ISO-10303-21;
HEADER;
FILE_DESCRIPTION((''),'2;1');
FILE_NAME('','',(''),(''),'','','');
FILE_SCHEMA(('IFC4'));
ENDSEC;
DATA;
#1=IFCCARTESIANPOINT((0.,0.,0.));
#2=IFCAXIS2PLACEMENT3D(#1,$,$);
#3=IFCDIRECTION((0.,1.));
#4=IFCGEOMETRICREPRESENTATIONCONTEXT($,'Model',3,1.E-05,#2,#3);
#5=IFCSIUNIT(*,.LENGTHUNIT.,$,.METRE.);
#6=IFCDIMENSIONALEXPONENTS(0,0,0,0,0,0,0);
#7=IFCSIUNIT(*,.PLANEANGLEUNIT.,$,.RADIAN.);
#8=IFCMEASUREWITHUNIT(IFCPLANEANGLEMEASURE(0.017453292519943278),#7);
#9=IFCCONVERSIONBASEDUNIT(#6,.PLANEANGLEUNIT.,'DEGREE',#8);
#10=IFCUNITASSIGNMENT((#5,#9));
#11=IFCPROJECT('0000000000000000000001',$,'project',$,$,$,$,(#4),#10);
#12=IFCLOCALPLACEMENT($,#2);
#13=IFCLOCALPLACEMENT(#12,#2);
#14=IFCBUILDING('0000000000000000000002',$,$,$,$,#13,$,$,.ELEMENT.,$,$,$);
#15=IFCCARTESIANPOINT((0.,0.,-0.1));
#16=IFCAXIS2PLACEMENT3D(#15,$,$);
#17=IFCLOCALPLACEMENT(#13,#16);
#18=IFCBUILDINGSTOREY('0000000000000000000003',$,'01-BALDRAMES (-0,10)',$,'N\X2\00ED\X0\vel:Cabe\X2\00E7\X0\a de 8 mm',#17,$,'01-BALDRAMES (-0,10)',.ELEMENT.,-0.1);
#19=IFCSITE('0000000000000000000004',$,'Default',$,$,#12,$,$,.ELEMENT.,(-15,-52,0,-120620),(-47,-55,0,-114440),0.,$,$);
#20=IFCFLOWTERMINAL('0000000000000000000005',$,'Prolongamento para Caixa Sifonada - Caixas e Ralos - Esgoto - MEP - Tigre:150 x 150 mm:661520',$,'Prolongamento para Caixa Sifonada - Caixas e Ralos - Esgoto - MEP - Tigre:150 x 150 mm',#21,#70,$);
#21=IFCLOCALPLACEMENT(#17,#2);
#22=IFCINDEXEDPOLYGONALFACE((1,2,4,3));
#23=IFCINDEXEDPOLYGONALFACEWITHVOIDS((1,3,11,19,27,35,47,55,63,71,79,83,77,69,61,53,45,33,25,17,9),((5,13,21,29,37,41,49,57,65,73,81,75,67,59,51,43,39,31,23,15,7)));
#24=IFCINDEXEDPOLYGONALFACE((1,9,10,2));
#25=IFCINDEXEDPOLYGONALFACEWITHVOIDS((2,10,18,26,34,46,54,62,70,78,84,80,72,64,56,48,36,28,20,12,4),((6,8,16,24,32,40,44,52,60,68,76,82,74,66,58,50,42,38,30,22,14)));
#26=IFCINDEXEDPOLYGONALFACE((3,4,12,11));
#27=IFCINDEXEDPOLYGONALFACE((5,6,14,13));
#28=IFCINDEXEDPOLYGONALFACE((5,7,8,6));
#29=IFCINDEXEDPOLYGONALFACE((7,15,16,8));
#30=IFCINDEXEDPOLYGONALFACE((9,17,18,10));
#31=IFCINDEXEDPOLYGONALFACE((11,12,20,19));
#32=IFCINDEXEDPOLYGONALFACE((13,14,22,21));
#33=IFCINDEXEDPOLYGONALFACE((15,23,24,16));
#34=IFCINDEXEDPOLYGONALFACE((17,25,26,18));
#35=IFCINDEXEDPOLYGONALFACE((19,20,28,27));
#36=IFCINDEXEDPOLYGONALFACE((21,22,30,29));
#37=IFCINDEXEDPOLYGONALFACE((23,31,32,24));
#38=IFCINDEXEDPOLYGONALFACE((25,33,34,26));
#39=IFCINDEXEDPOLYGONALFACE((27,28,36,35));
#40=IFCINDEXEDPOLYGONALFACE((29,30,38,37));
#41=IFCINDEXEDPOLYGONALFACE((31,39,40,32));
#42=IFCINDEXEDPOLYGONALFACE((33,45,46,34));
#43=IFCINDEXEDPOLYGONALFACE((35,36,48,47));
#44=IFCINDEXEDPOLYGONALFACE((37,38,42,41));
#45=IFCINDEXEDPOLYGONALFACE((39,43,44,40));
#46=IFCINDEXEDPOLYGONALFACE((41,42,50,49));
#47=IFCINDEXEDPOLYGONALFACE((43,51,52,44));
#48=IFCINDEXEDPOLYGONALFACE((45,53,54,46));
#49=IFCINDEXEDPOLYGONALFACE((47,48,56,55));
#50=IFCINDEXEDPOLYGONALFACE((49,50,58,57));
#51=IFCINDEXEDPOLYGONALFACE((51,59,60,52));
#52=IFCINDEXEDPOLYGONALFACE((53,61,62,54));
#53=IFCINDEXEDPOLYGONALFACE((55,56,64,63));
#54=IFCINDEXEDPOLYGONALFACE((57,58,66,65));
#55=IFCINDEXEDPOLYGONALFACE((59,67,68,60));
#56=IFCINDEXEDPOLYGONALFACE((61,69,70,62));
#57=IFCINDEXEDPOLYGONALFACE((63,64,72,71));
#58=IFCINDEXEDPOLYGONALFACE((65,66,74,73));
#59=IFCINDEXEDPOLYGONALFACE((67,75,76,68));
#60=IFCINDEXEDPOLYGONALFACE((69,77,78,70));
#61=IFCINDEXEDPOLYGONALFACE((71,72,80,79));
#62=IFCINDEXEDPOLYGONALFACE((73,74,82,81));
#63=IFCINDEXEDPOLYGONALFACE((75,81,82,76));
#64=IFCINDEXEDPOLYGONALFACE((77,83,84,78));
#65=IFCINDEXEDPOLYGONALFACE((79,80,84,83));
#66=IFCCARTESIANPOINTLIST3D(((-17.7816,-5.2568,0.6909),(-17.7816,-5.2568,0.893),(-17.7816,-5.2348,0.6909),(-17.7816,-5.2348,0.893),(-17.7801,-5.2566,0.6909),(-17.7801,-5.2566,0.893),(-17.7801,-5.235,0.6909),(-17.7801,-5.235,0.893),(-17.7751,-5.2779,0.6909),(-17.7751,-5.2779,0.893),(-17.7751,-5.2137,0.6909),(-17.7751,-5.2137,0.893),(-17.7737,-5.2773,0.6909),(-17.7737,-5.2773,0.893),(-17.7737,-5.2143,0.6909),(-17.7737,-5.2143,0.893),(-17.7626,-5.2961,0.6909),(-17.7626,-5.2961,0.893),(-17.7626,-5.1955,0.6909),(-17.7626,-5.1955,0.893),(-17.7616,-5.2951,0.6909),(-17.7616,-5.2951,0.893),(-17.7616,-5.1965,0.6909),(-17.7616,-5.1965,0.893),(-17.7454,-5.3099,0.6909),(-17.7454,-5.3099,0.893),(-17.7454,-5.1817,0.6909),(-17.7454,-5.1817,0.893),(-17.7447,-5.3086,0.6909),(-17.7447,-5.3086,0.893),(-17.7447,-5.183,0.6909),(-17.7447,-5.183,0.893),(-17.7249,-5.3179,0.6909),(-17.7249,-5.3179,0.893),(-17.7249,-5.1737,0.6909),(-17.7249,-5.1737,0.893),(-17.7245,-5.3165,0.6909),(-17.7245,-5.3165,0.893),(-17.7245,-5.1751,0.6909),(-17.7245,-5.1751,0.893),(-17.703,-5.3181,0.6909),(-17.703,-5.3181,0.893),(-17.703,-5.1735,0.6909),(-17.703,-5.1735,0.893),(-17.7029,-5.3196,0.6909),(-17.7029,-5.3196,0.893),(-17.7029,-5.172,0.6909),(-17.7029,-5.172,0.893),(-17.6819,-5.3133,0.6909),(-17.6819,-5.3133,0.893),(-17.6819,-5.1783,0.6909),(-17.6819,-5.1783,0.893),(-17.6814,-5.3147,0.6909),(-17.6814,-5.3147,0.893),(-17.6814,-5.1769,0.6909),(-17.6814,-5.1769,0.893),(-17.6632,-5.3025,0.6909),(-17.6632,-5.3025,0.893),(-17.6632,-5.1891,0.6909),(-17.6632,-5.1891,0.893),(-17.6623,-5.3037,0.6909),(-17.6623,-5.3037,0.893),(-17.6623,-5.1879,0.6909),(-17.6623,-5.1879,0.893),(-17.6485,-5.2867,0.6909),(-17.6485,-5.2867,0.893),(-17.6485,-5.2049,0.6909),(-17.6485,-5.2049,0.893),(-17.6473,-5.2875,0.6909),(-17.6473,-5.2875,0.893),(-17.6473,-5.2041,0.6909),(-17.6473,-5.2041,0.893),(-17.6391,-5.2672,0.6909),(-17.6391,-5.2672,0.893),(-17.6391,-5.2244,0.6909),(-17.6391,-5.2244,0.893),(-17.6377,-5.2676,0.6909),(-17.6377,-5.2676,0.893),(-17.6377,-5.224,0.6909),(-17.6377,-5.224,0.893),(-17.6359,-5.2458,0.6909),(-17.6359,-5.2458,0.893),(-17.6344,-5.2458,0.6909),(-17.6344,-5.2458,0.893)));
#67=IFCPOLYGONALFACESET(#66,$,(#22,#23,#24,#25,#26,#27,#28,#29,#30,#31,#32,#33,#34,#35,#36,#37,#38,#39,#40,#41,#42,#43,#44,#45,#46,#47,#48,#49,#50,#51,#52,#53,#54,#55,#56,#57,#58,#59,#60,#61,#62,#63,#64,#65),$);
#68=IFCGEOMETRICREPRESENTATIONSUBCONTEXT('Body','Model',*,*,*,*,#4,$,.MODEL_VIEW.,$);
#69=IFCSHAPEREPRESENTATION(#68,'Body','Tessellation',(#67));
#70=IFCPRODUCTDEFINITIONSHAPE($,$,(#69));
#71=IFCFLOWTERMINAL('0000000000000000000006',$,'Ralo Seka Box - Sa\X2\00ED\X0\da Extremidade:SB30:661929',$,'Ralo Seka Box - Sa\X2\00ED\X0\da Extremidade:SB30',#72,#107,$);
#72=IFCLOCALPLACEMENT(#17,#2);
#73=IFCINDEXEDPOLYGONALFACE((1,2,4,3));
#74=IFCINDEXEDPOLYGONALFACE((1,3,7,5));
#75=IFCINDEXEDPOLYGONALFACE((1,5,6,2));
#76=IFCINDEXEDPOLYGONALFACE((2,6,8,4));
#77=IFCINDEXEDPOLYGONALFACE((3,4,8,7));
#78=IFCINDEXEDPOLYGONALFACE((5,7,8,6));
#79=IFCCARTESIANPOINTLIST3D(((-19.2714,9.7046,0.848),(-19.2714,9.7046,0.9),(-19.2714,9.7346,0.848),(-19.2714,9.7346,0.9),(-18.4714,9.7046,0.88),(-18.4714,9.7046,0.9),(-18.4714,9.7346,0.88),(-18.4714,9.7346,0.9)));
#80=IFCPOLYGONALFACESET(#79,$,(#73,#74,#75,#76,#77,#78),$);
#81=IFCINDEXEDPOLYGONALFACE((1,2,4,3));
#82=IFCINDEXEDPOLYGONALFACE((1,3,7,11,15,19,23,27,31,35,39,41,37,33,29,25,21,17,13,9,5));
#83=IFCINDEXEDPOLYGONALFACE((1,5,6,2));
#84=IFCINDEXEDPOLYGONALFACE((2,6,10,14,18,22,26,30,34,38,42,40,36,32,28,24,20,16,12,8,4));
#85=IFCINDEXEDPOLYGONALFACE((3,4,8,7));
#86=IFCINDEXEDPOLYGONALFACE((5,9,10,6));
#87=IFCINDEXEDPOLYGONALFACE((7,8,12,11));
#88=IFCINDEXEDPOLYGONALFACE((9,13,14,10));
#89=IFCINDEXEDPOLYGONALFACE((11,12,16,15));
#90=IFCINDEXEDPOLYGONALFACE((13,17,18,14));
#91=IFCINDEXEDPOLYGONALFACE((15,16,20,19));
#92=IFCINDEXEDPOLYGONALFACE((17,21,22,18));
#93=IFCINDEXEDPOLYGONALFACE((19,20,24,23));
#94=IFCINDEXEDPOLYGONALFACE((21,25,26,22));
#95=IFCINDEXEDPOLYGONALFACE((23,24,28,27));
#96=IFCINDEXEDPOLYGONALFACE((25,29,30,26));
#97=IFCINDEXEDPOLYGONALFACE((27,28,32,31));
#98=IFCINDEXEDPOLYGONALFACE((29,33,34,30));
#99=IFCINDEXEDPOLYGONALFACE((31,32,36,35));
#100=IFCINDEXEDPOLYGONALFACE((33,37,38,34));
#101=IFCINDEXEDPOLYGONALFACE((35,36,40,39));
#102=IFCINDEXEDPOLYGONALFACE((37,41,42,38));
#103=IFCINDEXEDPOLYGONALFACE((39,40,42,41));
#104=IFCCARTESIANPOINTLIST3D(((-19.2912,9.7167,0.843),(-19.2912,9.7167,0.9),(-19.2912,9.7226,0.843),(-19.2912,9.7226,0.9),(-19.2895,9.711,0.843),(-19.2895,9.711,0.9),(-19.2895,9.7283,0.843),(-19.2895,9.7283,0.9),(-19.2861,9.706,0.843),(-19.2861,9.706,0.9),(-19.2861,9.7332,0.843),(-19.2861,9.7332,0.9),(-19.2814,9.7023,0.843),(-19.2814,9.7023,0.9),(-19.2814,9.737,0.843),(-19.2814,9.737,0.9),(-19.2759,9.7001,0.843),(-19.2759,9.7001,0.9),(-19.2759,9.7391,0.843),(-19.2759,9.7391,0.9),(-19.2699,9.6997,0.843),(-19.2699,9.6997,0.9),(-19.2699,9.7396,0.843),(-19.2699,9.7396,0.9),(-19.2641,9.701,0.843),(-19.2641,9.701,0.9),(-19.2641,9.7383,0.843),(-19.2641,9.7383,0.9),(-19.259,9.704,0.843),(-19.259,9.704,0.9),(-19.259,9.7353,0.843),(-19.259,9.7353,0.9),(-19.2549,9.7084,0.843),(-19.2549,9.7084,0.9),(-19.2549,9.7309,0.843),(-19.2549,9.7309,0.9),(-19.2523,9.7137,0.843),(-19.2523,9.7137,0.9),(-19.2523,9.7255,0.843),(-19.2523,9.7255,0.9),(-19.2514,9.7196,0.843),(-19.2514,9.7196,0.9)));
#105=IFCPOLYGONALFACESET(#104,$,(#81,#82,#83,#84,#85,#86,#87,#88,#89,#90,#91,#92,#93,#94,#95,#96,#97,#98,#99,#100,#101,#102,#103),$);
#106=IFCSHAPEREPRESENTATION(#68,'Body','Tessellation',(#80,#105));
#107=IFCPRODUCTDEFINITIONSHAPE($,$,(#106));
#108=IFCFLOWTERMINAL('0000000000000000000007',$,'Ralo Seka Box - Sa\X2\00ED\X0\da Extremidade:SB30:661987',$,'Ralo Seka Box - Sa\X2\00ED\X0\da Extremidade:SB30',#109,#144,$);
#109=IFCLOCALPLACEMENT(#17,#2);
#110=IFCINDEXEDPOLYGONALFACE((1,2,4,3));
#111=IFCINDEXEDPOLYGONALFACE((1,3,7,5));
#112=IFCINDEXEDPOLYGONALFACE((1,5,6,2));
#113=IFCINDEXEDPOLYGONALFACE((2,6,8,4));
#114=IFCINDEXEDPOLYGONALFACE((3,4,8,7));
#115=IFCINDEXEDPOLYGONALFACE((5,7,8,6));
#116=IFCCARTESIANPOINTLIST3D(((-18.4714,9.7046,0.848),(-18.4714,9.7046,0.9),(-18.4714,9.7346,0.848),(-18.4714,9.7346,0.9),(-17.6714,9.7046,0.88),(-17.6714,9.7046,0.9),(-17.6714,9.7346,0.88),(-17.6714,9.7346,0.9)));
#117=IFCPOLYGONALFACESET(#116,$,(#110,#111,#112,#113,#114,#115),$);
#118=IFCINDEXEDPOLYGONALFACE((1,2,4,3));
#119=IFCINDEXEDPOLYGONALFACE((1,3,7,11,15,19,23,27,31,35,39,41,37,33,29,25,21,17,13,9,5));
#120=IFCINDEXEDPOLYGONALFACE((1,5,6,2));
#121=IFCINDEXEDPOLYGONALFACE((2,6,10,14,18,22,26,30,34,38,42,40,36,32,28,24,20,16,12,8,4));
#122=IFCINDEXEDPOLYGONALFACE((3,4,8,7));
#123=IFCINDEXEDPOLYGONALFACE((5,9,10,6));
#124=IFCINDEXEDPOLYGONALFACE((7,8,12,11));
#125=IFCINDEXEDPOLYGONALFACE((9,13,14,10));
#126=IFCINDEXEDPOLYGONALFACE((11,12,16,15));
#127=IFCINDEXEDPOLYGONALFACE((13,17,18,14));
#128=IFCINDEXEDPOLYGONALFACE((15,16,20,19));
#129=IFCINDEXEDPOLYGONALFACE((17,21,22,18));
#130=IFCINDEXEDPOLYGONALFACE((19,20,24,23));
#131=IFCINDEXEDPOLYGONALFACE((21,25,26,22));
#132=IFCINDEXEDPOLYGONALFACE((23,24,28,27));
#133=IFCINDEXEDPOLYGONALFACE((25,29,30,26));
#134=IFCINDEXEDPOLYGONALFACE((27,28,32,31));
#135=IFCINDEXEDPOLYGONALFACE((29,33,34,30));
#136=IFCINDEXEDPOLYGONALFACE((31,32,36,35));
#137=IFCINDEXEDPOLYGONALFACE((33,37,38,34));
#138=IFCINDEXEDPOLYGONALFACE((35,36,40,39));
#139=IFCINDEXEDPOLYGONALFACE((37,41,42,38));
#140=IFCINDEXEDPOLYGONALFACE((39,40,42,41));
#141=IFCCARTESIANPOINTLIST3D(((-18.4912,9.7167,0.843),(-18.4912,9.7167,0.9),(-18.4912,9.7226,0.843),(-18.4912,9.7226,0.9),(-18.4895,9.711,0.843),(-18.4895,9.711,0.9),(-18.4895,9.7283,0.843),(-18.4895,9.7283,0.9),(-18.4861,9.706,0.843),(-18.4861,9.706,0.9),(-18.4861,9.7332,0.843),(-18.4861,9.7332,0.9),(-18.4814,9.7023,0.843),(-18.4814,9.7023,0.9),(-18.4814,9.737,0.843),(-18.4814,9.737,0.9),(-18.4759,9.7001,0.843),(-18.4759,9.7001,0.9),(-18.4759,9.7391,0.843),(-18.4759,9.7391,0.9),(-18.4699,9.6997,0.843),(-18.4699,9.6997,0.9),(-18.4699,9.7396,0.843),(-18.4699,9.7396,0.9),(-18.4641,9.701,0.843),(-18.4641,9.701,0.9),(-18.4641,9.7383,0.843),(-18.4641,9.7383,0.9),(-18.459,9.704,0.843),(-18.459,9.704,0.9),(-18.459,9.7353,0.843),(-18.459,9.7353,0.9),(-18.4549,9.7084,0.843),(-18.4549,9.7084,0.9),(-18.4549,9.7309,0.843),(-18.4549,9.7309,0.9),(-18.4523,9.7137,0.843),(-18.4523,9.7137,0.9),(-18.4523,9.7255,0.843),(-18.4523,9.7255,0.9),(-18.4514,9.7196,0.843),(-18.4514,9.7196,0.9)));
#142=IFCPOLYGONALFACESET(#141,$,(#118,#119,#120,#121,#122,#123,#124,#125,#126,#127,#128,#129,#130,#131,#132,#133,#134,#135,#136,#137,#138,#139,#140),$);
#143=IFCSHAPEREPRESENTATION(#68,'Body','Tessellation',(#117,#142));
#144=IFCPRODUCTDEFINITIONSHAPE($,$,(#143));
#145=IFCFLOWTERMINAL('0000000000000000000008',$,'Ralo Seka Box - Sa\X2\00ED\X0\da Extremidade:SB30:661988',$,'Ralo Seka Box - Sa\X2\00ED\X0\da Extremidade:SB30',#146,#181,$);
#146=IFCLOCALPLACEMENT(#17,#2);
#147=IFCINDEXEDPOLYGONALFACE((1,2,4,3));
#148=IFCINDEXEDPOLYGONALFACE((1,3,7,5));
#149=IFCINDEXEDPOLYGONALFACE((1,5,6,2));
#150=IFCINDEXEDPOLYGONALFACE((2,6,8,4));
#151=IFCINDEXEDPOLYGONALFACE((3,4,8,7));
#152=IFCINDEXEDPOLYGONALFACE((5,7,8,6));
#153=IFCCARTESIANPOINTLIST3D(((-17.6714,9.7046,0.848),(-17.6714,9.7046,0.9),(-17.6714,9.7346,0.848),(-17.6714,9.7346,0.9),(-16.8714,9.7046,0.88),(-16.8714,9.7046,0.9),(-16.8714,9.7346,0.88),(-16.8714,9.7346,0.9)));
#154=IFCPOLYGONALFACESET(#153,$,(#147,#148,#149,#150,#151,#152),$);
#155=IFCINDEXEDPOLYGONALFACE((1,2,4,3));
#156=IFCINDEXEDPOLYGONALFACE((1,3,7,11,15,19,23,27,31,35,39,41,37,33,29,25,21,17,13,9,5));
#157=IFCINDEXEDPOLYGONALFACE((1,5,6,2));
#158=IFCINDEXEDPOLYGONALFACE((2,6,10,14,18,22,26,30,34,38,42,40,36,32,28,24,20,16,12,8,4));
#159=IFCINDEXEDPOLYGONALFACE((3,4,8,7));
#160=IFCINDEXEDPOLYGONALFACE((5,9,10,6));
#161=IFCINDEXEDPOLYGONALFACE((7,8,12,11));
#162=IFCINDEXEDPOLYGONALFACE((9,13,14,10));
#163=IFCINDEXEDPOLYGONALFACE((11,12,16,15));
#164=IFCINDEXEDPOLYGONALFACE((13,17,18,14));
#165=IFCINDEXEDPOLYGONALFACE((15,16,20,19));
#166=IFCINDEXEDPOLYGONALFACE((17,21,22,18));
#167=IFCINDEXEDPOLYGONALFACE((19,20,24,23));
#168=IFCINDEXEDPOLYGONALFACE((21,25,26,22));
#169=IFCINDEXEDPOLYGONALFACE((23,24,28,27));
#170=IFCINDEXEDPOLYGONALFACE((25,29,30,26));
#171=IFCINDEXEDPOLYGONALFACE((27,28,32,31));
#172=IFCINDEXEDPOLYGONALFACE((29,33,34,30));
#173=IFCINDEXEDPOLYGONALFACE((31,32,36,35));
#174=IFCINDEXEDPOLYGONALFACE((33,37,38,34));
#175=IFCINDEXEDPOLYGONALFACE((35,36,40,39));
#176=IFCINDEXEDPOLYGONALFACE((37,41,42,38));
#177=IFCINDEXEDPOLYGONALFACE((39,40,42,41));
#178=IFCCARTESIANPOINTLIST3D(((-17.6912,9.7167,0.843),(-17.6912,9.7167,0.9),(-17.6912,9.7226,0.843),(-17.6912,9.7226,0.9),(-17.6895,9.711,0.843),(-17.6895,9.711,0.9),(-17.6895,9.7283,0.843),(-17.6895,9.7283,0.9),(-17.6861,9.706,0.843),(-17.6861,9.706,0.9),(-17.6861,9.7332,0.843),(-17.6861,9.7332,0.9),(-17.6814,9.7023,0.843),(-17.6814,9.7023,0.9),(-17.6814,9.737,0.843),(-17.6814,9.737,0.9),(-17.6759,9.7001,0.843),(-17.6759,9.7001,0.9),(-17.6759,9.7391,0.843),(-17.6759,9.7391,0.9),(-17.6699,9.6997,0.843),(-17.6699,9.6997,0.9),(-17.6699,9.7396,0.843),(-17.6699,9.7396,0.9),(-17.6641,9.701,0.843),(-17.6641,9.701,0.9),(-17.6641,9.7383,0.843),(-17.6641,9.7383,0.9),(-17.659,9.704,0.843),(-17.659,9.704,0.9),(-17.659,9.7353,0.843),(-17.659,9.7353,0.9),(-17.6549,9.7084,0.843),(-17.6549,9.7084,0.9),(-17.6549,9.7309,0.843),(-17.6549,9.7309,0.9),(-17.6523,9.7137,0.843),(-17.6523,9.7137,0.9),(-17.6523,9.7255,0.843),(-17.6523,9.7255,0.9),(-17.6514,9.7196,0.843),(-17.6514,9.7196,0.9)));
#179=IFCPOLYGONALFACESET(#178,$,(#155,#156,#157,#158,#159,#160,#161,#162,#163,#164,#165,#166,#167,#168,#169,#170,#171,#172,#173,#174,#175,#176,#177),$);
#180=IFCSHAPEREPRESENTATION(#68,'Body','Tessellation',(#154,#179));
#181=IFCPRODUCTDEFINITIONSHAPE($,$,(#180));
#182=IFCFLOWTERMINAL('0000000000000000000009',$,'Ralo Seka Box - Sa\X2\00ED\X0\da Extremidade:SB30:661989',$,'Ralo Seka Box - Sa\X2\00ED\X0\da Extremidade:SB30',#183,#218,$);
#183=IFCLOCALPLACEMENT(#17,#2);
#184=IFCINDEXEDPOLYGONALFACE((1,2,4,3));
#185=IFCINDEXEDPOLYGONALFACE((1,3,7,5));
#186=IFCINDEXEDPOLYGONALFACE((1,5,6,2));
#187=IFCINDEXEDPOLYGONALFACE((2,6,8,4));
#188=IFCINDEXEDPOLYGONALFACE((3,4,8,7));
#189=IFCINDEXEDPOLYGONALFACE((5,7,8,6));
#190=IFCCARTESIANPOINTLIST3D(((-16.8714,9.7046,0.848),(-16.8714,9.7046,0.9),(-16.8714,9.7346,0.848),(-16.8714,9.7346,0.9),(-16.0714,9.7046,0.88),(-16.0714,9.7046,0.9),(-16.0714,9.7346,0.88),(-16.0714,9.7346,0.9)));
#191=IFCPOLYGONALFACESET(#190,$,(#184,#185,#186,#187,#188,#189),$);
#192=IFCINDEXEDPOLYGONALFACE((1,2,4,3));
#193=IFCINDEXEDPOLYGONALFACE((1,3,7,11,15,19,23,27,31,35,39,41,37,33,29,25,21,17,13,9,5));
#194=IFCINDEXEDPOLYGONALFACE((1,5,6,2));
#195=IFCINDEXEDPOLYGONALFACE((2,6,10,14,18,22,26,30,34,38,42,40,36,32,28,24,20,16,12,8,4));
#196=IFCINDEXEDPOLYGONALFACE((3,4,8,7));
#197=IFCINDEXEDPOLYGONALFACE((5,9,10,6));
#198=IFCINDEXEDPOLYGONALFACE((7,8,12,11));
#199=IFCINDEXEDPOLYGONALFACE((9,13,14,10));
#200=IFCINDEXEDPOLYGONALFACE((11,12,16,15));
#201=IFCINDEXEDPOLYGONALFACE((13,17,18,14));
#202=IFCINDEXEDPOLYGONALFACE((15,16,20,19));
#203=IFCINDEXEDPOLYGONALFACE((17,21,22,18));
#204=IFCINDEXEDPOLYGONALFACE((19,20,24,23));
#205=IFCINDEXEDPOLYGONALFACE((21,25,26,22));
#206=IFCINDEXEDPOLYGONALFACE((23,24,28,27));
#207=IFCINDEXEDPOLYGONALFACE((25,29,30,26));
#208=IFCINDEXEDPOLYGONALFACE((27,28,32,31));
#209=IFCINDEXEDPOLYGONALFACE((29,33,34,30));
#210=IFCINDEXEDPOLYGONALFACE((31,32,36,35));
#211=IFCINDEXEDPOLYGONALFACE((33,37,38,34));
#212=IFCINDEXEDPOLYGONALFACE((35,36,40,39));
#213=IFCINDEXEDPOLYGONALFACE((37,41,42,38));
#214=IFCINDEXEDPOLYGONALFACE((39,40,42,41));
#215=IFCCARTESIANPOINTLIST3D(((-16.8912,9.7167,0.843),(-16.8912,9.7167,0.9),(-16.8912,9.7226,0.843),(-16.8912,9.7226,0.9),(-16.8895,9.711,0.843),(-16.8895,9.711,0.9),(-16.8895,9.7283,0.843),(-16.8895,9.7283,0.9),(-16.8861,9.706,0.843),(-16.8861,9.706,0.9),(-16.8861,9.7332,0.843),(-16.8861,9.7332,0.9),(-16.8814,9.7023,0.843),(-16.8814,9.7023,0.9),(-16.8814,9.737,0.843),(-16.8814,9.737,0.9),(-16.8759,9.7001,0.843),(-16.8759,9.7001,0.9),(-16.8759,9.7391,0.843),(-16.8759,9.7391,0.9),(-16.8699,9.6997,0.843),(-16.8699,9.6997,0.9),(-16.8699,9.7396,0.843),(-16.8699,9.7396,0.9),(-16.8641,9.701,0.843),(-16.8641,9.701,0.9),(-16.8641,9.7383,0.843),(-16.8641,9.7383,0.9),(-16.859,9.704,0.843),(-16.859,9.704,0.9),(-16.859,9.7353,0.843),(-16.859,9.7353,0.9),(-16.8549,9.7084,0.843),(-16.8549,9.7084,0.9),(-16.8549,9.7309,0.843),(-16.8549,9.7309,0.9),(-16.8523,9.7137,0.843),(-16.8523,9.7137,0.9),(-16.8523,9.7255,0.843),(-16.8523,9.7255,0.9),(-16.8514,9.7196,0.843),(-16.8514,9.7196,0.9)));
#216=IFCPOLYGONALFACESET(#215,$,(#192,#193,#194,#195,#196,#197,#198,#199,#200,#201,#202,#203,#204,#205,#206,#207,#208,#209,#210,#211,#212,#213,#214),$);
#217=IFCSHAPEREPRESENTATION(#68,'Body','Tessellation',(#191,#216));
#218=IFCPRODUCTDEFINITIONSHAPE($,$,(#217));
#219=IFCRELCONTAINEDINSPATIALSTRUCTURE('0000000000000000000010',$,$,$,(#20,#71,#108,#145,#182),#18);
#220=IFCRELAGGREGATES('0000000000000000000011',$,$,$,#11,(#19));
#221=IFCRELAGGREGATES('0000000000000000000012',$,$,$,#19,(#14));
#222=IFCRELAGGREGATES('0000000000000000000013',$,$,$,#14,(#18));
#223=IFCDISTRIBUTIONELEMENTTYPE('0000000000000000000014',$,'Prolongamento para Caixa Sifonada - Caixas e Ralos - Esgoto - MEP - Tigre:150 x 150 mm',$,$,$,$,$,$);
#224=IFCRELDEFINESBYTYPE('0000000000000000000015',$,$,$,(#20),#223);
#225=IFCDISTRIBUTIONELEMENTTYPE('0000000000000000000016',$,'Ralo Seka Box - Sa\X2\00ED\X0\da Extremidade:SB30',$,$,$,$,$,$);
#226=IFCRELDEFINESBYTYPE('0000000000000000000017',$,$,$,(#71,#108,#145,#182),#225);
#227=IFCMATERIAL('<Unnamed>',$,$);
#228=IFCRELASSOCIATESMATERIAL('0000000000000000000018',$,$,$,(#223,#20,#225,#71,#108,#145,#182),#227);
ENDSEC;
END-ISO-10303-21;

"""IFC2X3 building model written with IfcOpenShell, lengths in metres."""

from ifc_helpers import new_model, entity, si_unit, converted_unit, direction, frame, frame_2d, origin, place, context, subcontext, project, spatial, polyline, circle, hollow_circle, outline, extrude, source, transform, mapped, material, type_object, type_shapes, element, save


model = new_model("IFC2X3")

# Units and contexts
model_context = context("Model", 3, precision=1e-05, world=origin(), true_north=direction((0.0, 1.0)))
body_context = subcontext(model_context, "Body", "Model", "MODEL_VIEW")
ifc_project = project(units=[si_unit("LENGTHUNIT", "METRE"), converted_unit("PLANEANGLEUNIT", "DEGREE", entity("IfcPlaneAngleMeasure", 0.017453292519943278), si_unit("PLANEANGLEUNIT", "RADIAN"), dimensions=[0, 0, 0, 0, 0, 0, 0])], contexts=[model_context])

# Site, building, storey
site_placement = place(None, origin())
site = spatial("IfcSite", under=ifc_project, at=site_placement, Name="Default", CompositionType="ELEMENT", RefLatitude=(-15, -52, 0, -120620), RefLongitude=(-47, -55, 0, -114440), RefElevation=0.0)
building_placement = place(site_placement, origin())
building = spatial("IfcBuilding", under=site, at=building_placement, CompositionType="ELEMENT")
storey_placement = place(building_placement, frame((0.0, 0.0, -0.1)))
storey = spatial("IfcBuildingStorey", under=building, at=storey_placement, Name="01-BALDRAMES (-0,10)", ObjectType="Nível:Cabeça de 8 mm", LongName="01-BALDRAMES (-0,10)", CompositionType="ELEMENT", Elevation=-0.1)

# Flow terminal
ifc_material = material(Name="<Unnamed>")
distribution_element_type_1 = type_object("IfcDistributionElementType", Name="Prolongamento para Caixa Sifonada - Caixas e Ralos - Esgoto - MEP - Tigre:150 x 150 mm", material=ifc_material)
shared_shape_1 = source(origin(), body_context, "Body", "SweptSolid", [
    extrude(hollow_circle(Radius=0.074, WallThickness=0.0015, at=frame_2d((0.0, 0.0), x_axis=(1.0, 0.0))), frame((0.0, 0.0, -0.2021)), (0.0, 0.0, 1.0), 0.2021),
])
type_shapes(distribution_element_type_1, [shared_shape_1])
flow_terminal_1_placement = place(storey_placement, frame((-17.7084, -5.2458, 0.893)))
element("IfcFlowTerminal", 1, at=flow_terminal_1_placement, inside=storey, type_object=distribution_element_type_1, material=ifc_material, Name="Prolongamento para Caixa Sifonada - Caixas e Ralos - Esgoto - MEP - Tigre:150 x 150 mm:661520", ObjectType="Prolongamento para Caixa Sifonada - Caixas e Ralos - Esgoto - MEP - Tigre:150 x 150 mm", context=body_context, shape_type="MappedRepresentation", body=[
    mapped(shared_shape_1, transform((0.0, 0.0, 0.0), scale=1.0)),
])

# Flow terminals
distribution_element_type_2 = type_object("IfcDistributionElementType", Name="Ralo Seka Box - Saída Extremidade:SB30", material=ifc_material)
shared_shape_2 = source(origin(), body_context, "Body", "SweptSolid", [
    extrude(outline(polyline([(-0.3996, -0.018), (0.401, -0.018), (0.399, 0.034), (-0.4004, 0.002), (-0.3996, -0.018)])), frame((0.4, -0.015, -0.018), z_axis=(0.0, 1.0, 0.0), x_axis=(-0.999201, 0.0, -0.039968)), (0.0, 0.0, 1.0), 0.03),
    extrude(circle(Radius=0.02, at=frame_2d((0.0, 0.0), x_axis=(1.0, 0.0))), frame((0.0, 0.0, -0.057)), (0.0, 0.0, 1.0), 0.057),
])
type_shapes(distribution_element_type_2, [shared_shape_2])
for number, where, name in (
    (2, (-19.2714, 9.7196, 0.9), "Ralo Seka Box - Saída Extremidade:SB30:661929"),
    (3, (-18.4714, 9.7196, 0.9), "Ralo Seka Box - Saída Extremidade:SB30:661987"),
    (4, (-17.6714, 9.7196, 0.9), "Ralo Seka Box - Saída Extremidade:SB30:661988"),
    (5, (-16.8714, 9.7196, 0.9), "Ralo Seka Box - Saída Extremidade:SB30:661989"),
):
    element("IfcFlowTerminal", number, at=place(storey_placement, frame(where)), inside=storey, type_object=distribution_element_type_2, material=ifc_material, Name=name, ObjectType="Ralo Seka Box - Saída Extremidade:SB30", context=body_context, shape_type="MappedRepresentation", body=[
        mapped(shared_shape_2, transform((0.0, 0.0, 0.0), scale=1.0)),
    ])

save(model, "model.ifc")
